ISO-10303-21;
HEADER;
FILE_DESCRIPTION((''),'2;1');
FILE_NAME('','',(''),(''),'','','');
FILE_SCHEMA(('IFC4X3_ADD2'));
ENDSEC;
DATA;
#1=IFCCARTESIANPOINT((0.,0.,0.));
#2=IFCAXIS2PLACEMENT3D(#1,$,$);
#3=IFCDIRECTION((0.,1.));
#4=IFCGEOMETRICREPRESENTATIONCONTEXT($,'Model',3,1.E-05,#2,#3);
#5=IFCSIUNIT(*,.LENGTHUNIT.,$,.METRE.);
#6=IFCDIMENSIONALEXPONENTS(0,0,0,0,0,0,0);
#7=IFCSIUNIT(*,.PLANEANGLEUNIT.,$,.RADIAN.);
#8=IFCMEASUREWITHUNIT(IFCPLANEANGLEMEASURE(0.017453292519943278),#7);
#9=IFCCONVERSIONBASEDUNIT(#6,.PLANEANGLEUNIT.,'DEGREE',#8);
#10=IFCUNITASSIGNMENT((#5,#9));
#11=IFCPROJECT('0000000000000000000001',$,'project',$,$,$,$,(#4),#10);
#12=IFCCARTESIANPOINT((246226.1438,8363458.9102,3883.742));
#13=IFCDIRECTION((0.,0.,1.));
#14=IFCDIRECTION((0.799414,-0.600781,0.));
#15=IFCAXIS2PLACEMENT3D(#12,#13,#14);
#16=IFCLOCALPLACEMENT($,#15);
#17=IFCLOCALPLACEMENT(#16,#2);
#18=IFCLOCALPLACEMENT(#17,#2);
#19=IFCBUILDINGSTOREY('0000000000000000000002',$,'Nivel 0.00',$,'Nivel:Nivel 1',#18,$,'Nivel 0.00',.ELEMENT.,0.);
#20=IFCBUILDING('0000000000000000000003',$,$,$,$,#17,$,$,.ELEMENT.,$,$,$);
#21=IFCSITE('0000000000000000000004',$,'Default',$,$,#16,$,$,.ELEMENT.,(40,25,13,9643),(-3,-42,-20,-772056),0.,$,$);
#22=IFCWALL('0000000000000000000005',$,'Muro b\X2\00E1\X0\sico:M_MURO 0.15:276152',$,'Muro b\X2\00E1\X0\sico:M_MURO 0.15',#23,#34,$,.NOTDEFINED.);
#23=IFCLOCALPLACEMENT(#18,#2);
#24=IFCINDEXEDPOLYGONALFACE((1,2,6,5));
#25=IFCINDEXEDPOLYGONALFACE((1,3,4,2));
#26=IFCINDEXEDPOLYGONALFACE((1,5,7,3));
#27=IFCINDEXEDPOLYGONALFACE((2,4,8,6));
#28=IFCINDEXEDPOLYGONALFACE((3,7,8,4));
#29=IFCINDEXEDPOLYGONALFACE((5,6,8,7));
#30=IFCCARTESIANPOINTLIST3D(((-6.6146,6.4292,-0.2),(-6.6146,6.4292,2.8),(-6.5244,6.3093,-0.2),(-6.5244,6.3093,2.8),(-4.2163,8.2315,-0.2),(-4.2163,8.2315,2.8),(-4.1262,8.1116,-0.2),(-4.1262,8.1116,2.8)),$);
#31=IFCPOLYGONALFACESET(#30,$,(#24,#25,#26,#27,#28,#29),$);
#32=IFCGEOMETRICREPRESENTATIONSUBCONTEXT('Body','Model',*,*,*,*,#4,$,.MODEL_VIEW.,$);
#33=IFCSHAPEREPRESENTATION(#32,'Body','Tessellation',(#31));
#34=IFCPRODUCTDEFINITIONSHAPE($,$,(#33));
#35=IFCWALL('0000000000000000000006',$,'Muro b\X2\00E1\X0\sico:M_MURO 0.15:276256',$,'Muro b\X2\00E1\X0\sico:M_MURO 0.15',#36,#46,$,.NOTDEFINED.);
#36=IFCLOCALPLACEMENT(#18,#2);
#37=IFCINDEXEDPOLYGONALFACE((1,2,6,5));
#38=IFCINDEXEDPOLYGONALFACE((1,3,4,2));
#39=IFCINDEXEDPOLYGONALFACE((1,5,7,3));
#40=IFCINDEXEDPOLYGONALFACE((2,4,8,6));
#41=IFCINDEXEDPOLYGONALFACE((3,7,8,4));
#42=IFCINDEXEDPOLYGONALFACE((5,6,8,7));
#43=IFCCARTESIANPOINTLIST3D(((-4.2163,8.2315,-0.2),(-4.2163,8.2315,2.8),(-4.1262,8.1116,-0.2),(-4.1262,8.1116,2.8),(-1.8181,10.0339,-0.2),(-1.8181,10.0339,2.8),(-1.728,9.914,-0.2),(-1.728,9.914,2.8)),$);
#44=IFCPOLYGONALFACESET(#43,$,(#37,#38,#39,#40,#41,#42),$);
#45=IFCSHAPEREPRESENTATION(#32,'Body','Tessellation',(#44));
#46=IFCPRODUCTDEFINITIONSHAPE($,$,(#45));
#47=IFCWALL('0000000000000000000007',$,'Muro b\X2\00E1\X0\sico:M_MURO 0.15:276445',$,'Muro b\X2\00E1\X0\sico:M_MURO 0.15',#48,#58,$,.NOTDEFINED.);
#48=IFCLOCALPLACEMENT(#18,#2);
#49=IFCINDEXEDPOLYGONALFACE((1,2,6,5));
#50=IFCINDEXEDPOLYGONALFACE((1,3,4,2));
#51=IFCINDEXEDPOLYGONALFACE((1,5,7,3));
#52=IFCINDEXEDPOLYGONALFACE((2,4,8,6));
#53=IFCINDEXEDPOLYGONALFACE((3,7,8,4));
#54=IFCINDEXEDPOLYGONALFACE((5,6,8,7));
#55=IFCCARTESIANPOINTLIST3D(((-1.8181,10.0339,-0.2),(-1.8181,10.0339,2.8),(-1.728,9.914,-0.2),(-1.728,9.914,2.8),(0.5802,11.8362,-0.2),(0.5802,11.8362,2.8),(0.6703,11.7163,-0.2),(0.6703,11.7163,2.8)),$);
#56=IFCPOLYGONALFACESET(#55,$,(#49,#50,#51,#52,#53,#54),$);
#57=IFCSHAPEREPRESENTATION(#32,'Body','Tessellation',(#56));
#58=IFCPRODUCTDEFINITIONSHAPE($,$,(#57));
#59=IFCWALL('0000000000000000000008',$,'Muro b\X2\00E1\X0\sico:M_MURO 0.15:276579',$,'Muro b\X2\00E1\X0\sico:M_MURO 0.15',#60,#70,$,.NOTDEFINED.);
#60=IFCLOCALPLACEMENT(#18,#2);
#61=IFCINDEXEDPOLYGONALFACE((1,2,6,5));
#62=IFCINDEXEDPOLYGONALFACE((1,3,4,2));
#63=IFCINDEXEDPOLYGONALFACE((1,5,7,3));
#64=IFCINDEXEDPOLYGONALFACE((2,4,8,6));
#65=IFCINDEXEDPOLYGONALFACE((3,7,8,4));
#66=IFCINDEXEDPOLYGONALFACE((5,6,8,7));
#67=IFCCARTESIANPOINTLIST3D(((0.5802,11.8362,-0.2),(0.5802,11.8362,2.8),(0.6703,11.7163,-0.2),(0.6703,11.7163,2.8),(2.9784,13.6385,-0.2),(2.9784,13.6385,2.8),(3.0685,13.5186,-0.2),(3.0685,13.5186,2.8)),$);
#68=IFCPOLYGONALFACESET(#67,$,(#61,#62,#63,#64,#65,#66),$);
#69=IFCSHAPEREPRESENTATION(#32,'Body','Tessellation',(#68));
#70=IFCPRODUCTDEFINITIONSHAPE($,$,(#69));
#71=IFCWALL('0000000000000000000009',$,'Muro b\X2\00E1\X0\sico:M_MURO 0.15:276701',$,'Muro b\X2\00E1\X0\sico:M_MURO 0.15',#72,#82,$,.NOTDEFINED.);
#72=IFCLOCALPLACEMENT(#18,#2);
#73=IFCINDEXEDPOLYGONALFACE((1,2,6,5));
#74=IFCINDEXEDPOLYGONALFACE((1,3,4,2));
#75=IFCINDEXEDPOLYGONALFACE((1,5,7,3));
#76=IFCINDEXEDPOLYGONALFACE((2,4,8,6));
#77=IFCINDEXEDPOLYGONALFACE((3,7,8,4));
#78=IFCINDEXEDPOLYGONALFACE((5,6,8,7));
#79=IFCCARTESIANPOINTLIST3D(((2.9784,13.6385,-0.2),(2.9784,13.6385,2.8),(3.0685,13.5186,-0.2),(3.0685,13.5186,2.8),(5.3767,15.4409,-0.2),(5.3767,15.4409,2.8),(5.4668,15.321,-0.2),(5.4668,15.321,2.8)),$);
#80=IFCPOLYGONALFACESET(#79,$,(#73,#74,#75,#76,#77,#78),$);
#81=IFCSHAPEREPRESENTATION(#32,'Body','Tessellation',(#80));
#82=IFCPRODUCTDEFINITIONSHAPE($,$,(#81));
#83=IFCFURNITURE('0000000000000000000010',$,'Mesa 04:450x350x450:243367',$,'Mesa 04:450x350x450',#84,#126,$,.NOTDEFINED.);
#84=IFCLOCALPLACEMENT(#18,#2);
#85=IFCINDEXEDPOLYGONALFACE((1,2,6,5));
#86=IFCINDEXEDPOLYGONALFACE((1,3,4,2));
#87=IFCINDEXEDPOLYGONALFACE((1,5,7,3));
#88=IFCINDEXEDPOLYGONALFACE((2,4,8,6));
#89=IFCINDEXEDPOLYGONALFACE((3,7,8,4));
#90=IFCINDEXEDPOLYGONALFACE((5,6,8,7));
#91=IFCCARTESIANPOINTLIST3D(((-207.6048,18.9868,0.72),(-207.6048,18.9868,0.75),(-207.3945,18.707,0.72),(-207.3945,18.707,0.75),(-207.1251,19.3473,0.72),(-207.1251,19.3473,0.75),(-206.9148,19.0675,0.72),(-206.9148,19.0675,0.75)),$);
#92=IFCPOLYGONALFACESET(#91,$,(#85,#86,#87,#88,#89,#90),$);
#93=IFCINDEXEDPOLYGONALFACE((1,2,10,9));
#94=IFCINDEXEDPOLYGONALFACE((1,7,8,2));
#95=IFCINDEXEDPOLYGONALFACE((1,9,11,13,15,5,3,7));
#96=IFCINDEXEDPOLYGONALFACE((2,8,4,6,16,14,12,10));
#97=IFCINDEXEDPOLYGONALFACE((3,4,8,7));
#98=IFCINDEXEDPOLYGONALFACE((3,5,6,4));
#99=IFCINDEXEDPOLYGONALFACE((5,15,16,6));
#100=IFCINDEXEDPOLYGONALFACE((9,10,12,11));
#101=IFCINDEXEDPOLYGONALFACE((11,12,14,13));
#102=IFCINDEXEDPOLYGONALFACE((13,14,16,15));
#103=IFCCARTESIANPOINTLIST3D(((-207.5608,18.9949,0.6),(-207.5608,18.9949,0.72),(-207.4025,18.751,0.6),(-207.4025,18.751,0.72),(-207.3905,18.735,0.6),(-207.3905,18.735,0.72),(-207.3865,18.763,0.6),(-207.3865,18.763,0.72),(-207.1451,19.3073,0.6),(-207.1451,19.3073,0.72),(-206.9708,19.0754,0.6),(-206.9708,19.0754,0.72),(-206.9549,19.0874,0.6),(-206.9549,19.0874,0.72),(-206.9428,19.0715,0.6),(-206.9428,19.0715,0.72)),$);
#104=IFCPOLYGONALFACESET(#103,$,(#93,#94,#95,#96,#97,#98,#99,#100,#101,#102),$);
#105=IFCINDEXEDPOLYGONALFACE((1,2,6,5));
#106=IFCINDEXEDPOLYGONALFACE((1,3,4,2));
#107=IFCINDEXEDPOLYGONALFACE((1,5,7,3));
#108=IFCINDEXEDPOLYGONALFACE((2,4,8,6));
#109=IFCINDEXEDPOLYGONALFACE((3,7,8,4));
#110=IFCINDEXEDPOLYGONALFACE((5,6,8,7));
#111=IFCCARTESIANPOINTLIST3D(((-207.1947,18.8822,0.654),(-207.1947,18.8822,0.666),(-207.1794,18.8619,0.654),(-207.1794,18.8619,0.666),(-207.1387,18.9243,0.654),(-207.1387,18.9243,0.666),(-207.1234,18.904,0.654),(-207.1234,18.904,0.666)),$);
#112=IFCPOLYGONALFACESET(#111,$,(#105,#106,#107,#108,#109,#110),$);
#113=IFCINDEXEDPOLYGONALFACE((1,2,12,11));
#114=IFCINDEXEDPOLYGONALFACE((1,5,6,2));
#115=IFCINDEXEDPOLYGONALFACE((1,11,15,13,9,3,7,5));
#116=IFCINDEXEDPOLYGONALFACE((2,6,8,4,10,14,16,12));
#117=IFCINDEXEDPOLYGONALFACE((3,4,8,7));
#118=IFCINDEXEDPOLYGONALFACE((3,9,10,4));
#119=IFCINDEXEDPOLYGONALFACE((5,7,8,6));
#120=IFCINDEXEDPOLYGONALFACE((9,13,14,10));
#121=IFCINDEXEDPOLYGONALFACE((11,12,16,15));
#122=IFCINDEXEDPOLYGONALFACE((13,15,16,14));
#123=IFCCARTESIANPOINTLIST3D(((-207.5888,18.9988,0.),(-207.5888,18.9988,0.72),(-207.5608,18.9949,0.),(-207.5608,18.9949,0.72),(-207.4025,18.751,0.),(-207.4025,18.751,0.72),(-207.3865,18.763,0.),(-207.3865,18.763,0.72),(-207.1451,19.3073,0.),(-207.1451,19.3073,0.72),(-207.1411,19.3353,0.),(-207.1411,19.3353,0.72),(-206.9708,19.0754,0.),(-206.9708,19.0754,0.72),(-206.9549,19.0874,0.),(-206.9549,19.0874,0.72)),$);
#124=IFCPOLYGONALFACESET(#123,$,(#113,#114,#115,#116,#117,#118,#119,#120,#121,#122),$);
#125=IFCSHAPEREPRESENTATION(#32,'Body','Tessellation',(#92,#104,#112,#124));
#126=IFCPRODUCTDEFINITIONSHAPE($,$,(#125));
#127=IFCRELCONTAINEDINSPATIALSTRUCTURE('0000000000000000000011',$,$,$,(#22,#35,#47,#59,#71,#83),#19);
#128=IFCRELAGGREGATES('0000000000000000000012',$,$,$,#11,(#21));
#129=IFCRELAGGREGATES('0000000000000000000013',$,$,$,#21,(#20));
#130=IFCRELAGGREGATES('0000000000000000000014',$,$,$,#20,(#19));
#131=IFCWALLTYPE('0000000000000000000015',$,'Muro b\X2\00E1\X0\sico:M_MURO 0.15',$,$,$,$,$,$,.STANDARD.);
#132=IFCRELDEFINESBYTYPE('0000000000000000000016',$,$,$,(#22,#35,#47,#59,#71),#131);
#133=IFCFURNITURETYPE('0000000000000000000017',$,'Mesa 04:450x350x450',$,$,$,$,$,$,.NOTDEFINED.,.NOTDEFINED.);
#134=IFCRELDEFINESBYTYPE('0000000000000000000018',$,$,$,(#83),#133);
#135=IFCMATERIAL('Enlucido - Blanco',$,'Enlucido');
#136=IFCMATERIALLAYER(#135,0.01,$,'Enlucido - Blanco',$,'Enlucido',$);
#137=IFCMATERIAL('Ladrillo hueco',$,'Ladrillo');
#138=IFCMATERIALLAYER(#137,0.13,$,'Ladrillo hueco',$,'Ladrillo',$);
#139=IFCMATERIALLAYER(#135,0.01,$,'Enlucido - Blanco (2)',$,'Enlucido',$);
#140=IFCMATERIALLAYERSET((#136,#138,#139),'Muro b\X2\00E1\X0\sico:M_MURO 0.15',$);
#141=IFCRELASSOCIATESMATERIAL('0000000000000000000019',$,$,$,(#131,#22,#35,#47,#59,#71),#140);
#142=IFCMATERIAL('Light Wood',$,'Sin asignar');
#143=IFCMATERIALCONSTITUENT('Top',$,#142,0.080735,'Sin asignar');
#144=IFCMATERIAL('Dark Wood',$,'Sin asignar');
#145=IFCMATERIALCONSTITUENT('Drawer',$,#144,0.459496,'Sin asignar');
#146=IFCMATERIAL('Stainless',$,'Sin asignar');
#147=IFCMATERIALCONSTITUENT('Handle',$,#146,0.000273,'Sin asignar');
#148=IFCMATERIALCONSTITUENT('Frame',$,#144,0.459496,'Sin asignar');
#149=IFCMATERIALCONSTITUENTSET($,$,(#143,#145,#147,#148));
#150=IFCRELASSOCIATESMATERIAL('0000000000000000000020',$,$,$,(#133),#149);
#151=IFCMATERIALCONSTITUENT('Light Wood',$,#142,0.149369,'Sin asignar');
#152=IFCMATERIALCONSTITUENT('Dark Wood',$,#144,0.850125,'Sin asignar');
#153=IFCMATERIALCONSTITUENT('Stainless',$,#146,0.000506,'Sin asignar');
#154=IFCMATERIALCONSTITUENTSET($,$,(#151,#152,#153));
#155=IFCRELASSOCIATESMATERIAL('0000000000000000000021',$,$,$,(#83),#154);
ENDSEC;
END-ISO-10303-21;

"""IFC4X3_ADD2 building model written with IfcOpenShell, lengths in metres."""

from ifc_helpers import new_model, entity, si_unit, converted_unit, direction, frame, frame_2d, origin, origin_2d_with_axis, place, context, subcontext, project, spatial, polyline, rectangle, outline, extrude, source, transform, mapped, material, layer, layer_set, constituent, constituent_set, type_object, type_shapes, element, save


model = new_model("IFC4X3_ADD2")

# Units and contexts
model_context = context("Model", 3, precision=1e-05, world=origin(), true_north=direction((0.0, 1.0)))
body_context = subcontext(model_context, "Body", "Model", "MODEL_VIEW")
ifc_project = project(units=[si_unit("LENGTHUNIT", "METRE"), converted_unit("PLANEANGLEUNIT", "DEGREE", entity("IfcPlaneAngleMeasure", 0.017453292519943278), si_unit("PLANEANGLEUNIT", "RADIAN"), dimensions=[0, 0, 0, 0, 0, 0, 0])], contexts=[model_context])

# Site, building, storey
site_placement = place(None, frame((246226.1438, 8363458.9102, 3883.742), z_axis=(0.0, 0.0, 1.0), x_axis=(0.799414, -0.600781, 0.0)))
site = spatial("IfcSite", under=ifc_project, at=site_placement, Name="Default", CompositionType="ELEMENT", RefLatitude=(40, 25, 13, 9643), RefLongitude=(-3, -42, -20, -772056), RefElevation=0.0)
building_placement = place(site_placement, origin())
building = spatial("IfcBuilding", under=site, at=building_placement, CompositionType="ELEMENT")
storey_placement = place(building_placement, origin())
storey = spatial("IfcBuildingStorey", under=building, at=storey_placement, Name="Nivel 0.00", ObjectType="Nivel:Nivel 1", LongName="Nivel 0.00", CompositionType="ELEMENT", Elevation=0.0)

# Walls
ifc_material_1 = material(Name="Enlucido - Blanco", Category="Enlucido")
ifc_layer_1 = layer(ifc_material_1, 0.01, Name="Enlucido - Blanco", Category="Enlucido")
ifc_material_2 = material(Name="Ladrillo hueco", Category="Ladrillo")
ifc_layer_2 = layer(ifc_material_2, 0.13, Name="Ladrillo hueco", Category="Ladrillo")
ifc_layer_3 = layer(ifc_material_1, 0.01, Name="Enlucido - Blanco (2)", Category="Enlucido")
ifc_layer_set = layer_set([ifc_layer_1, ifc_layer_2, ifc_layer_3], Name="Muro básico:M_MURO 0.15")
wall_type = type_object("IfcWallType", Name="Muro básico:M_MURO 0.15", PredefinedType="STANDARD", material=ifc_layer_set)
wall_1_placement = place(storey_placement, frame((-6.5695, 6.3692, -0.2), z_axis=(0.0, 0.0, 1.0), x_axis=(0.799414, 0.60078, 0.0)))
element("IfcWall", 1, at=wall_1_placement, inside=storey, type_object=wall_type, material=ifc_layer_set, Name="Muro básico:M_MURO 0.15:276152", ObjectType="Muro básico:M_MURO 0.15", PredefinedType="NOTDEFINED", context=body_context, shape_type="SweptSolid", body=[
    extrude(rectangle(XDim=3.0, YDim=0.15, at=frame_2d((1.5, 0.0), x_axis=(-1.0, 0.0))), origin(), (0.0, 0.0, 1.0), 3.0),
])
wall_2_placement = place(storey_placement, frame((-4.1713, 8.1716, -0.2), z_axis=(0.0, 0.0, 1.0), x_axis=(0.799414, 0.60078, 0.0)))
element("IfcWall", 2, at=wall_2_placement, inside=storey, type_object=wall_type, material=ifc_layer_set, Name="Muro básico:M_MURO 0.15:276256", ObjectType="Muro básico:M_MURO 0.15", PredefinedType="NOTDEFINED", context=body_context, shape_type="SweptSolid", body=[
    extrude(rectangle(XDim=3.0, YDim=0.15, at=frame_2d((1.5, 0.0), x_axis=(-1.0, 0.0))), origin(), (0.0, 0.0, 1.0), 3.0),
])
wall_3_placement = place(storey_placement, frame((-1.773, 9.9739, -0.2), z_axis=(0.0, 0.0, 1.0), x_axis=(0.799414, 0.60078, 0.0)))
element("IfcWall", 3, at=wall_3_placement, inside=storey, type_object=wall_type, material=ifc_layer_set, Name="Muro básico:M_MURO 0.15:276445", ObjectType="Muro básico:M_MURO 0.15", PredefinedType="NOTDEFINED", context=body_context, shape_type="SweptSolid", body=[
    extrude(rectangle(XDim=3.0, YDim=0.15, at=frame_2d((1.5, 0.0), x_axis=(-1.0, 0.0))), origin(), (0.0, 0.0, 1.0), 3.0),
])
wall_4_placement = place(storey_placement, frame((0.6252, 11.7763, -0.2), z_axis=(0.0, 0.0, 1.0), x_axis=(0.799414, 0.60078, 0.0)))
element("IfcWall", 4, at=wall_4_placement, inside=storey, type_object=wall_type, material=ifc_layer_set, Name="Muro básico:M_MURO 0.15:276579", ObjectType="Muro básico:M_MURO 0.15", PredefinedType="NOTDEFINED", context=body_context, shape_type="SweptSolid", body=[
    extrude(rectangle(XDim=3.0, YDim=0.15, at=frame_2d((1.5, 0.0), x_axis=(-1.0, 0.0))), origin(), (0.0, 0.0, 1.0), 3.0),
])
wall_5_placement = place(storey_placement, frame((3.0235, 13.5786, -0.2), z_axis=(0.0, 0.0, 1.0), x_axis=(0.799414, 0.60078, 0.0)))
element("IfcWall", 5, at=wall_5_placement, inside=storey, type_object=wall_type, material=ifc_layer_set, Name="Muro básico:M_MURO 0.15:276701", ObjectType="Muro básico:M_MURO 0.15", PredefinedType="NOTDEFINED", context=body_context, shape_type="SweptSolid", body=[
    extrude(rectangle(XDim=3.0, YDim=0.15, at=frame_2d((1.5, 0.0), x_axis=(-1.0, 0.0))), origin(), (0.0, 0.0, 1.0), 3.0),
])

# Furniture
ifc_material_3 = material(Name="Light Wood", Category="Sin asignar")
ifc_constituent_1 = constituent(ifc_material_3, Name="Light Wood", Category="Sin asignar", fraction=0.149369)
ifc_material_4 = material(Name="Dark Wood", Category="Sin asignar")
ifc_constituent_2 = constituent(ifc_material_4, Name="Dark Wood", Category="Sin asignar", fraction=0.850125)
ifc_material_5 = material(Name="Stainless", Category="Sin asignar")
ifc_constituent_3 = constituent(ifc_material_5, Name="Stainless", Category="Sin asignar", fraction=0.000506)
ifc_constituent_set_1 = constituent_set(constituents=[ifc_constituent_1, ifc_constituent_2, ifc_constituent_3])
ifc_constituent_4 = constituent(ifc_material_3, Name="Top", Category="Sin asignar", fraction=0.080735)
ifc_constituent_5 = constituent(ifc_material_4, Name="Drawer", Category="Sin asignar", fraction=0.459496)
ifc_constituent_6 = constituent(ifc_material_5, Name="Handle", Category="Sin asignar", fraction=0.000273)
ifc_constituent_7 = constituent(ifc_material_4, Name="Frame", Category="Sin asignar", fraction=0.459496)
ifc_constituent_set_2 = constituent_set(constituents=[ifc_constituent_4, ifc_constituent_5, ifc_constituent_6, ifc_constituent_7])
furniture_type = type_object("IfcFurnitureType", Name="Mesa 04:450x350x450", AssemblyPlace="NOTDEFINED", PredefinedType="NOTDEFINED", material=ifc_constituent_set_2)
shared_shape = source(origin(), body_context, "Body", "SweptSolid", [
    extrude(rectangle(XDim=0.35, YDim=0.6, at=origin_2d_with_axis()), frame((0.0, -0.0736, 0.72), z_axis=(0.0, 0.0, 1.0), x_axis=(0.0, -1.0, 0.0)), (0.0, 0.0, 1.0), 0.03),
    extrude(outline(polyline([(0.0675, -0.28), (0.0875, -0.28), (0.0875, 0.28), (0.0675, 0.28), (0.0675, 0.26), (-0.2225, 0.26), (-0.2225, -0.26), (0.0675, -0.26), (0.0675, -0.28)])), frame((0.0, -0.1411, 0.6), z_axis=(0.0, 0.0, 1.0), x_axis=(0.0, -1.0, 0.0)), (0.0, 0.0, 1.0), 0.12),
    extrude(rectangle(XDim=0.0254, YDim=0.07, at=frame_2d((0.0, 0.0), x_axis=(1.0, 0.0))), frame((0.0, -0.2413, 0.654), z_axis=(0.0, 0.0, 1.0), x_axis=(0.0, 1.0, 0.0)), (0.0, 0.0, 1.0), 0.012),
    extrude(outline(polyline([(-0.28, -0.15), (-0.26, -0.15), (-0.26, 0.14), (0.26, 0.14), (0.26, -0.15), (0.28, -0.15), (0.28, 0.16), (-0.28, 0.16), (-0.28, -0.15)])), frame((0.0, -0.0586, 0.0)), (0.0, 0.0, 1.0), 0.72),
])
type_shapes(furniture_type, [shared_shape])
furniture_placement = place(storey_placement, frame((-207.304, 19.086, 0.0), z_axis=(0.0, 0.0, 1.0), x_axis=(0.799414, 0.60078, 0.0)))
element("IfcFurniture", 6, at=furniture_placement, inside=storey, type_object=furniture_type, material=ifc_constituent_set_1, Name="Mesa 04:450x350x450:243367", ObjectType="Mesa 04:450x350x450", PredefinedType="NOTDEFINED", context=body_context, shape_type="MappedRepresentation", body=[
    mapped(shared_shape, transform((0.0, 0.0, 0.0), scale=1.0)),
])

save(model, "model.ifc")
